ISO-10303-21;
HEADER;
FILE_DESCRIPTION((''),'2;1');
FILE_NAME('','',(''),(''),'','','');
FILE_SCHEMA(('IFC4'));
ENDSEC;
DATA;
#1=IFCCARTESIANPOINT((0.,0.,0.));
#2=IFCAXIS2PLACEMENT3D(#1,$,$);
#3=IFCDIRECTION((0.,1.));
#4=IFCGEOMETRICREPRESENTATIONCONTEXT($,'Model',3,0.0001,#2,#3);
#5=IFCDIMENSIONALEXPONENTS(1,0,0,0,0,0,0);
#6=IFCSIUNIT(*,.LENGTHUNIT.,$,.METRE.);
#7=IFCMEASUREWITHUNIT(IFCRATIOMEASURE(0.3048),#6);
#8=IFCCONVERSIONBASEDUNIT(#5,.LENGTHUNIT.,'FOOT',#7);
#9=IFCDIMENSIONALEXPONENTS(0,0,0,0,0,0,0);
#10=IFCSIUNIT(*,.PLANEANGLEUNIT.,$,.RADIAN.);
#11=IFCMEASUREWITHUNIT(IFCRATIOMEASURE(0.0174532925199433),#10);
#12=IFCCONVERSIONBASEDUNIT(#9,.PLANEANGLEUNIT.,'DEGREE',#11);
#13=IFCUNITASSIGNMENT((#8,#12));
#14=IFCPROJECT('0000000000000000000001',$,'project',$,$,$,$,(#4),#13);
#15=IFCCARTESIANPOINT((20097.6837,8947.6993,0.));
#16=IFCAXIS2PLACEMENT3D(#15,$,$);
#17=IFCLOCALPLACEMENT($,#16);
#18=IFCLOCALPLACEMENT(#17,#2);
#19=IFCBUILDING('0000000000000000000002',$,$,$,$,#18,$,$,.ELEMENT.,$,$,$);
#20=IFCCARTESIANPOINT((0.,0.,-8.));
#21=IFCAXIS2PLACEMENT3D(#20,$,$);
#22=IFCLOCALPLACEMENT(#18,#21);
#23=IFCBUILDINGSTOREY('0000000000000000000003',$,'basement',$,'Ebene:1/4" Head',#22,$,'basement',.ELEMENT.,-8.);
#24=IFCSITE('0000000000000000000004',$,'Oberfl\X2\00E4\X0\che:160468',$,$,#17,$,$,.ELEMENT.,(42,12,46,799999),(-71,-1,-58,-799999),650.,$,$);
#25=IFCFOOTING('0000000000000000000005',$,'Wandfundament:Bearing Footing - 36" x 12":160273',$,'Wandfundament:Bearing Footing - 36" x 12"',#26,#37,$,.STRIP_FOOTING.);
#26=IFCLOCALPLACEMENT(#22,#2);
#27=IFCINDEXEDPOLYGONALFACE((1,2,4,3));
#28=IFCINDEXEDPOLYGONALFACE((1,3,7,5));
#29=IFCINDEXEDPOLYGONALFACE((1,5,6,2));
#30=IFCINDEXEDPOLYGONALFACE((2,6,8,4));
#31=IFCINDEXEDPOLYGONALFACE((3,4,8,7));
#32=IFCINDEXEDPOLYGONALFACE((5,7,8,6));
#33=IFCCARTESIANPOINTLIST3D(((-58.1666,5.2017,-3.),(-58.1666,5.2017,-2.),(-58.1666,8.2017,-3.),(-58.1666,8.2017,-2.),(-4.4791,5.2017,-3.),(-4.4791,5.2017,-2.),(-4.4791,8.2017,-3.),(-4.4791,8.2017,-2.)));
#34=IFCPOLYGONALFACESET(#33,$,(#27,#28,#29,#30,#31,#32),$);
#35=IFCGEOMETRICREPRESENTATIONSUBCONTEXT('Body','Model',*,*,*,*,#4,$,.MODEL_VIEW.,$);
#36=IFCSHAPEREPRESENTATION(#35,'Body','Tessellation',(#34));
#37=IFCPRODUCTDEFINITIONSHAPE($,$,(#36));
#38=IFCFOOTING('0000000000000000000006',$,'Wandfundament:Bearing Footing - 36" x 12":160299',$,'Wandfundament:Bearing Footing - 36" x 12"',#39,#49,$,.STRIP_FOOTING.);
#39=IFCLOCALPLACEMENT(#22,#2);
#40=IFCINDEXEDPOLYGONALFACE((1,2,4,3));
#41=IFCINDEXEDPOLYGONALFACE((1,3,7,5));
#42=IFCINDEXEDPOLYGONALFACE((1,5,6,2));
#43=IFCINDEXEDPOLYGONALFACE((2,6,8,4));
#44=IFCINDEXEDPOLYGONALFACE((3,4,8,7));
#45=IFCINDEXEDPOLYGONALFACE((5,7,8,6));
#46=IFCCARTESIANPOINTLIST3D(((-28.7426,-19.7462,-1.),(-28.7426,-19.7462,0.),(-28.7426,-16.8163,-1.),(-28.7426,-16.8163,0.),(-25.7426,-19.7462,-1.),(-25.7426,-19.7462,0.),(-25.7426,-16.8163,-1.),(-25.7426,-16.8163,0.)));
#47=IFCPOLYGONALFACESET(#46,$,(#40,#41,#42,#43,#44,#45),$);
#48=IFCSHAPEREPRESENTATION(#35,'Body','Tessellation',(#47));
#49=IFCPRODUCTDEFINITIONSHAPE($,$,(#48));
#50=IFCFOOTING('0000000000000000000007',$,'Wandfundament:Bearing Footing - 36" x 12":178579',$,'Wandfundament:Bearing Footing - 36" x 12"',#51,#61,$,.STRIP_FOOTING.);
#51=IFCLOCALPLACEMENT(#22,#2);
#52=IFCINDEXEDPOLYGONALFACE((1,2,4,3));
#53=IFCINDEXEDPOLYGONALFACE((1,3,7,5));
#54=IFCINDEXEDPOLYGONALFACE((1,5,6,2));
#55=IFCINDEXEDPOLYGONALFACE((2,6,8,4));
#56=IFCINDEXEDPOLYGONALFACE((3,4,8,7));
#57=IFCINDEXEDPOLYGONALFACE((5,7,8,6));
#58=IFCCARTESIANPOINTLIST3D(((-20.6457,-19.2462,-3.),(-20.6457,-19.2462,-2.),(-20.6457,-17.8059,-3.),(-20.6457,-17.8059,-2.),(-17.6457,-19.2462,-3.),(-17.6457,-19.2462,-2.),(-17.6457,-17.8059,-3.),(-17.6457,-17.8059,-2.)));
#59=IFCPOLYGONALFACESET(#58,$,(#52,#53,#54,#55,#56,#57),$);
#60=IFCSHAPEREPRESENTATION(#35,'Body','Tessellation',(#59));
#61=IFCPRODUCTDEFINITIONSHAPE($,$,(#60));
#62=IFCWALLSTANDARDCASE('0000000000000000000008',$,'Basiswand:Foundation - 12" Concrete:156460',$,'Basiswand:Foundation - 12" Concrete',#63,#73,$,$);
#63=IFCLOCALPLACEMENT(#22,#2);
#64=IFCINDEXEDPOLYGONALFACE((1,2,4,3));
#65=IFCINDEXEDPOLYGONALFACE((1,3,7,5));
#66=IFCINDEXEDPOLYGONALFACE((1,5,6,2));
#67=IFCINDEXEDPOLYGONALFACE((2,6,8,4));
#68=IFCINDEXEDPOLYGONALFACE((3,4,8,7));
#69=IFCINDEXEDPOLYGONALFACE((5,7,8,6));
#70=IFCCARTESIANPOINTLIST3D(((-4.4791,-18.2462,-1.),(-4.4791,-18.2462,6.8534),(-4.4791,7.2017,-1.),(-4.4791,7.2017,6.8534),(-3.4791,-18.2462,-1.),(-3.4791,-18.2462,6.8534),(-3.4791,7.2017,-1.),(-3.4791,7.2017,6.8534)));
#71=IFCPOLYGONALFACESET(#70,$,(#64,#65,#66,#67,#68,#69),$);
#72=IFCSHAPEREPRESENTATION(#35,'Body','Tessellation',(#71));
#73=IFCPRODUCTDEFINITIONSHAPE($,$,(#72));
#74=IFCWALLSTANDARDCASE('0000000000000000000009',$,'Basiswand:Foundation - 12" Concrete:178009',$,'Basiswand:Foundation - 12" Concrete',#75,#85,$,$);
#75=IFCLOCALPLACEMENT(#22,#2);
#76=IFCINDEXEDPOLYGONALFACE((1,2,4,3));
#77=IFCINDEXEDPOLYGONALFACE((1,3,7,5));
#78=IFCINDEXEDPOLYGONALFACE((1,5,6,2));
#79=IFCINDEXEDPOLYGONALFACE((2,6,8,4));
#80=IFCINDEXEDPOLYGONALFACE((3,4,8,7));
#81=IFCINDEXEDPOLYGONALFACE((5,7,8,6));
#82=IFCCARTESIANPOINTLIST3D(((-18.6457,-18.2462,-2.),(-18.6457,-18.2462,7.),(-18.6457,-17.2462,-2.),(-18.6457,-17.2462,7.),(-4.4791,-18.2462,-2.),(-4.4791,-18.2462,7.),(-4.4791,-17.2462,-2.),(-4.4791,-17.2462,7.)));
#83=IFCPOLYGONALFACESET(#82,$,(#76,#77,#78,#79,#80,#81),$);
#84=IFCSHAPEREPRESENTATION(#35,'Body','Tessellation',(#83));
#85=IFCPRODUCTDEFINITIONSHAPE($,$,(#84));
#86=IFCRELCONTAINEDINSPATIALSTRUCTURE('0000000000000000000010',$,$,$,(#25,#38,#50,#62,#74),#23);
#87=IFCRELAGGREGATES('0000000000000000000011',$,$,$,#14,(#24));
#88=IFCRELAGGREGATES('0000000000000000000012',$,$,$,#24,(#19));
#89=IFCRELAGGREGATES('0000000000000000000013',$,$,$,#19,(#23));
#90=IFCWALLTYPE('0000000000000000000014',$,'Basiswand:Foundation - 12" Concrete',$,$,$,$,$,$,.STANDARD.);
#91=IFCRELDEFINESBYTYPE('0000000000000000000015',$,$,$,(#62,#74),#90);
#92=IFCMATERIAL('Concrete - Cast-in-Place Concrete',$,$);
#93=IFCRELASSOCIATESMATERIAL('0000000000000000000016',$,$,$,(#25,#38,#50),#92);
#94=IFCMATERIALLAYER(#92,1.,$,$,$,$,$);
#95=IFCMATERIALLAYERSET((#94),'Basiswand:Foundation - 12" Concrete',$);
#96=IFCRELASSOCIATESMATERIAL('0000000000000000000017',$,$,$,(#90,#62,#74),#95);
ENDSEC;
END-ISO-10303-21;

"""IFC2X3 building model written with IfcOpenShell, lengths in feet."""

from ifc_helpers import new_model, entity, si_unit, converted_unit, direction, frame, frame_2d, origin, place, context, subcontext, project, spatial, rectangle, extrude, material, layer, layer_set, layer_usage, type_object, element, save


model = new_model("IFC2X3")

# Units and contexts
model_context = context("Model", 3, precision=0.0001, world=origin(), true_north=direction((0.0, 1.0)))
body_context = subcontext(model_context, "Body", "Model", "MODEL_VIEW")
ifc_project = project(units=[converted_unit("LENGTHUNIT", "FOOT", entity("IfcRatioMeasure", 0.3048), si_unit("LENGTHUNIT", "METRE"), dimensions=[1, 0, 0, 0, 0, 0, 0]), converted_unit("PLANEANGLEUNIT", "DEGREE", entity("IfcRatioMeasure", 0.0174532925199433), si_unit("PLANEANGLEUNIT", "RADIAN"), dimensions=[0, 0, 0, 0, 0, 0, 0])], contexts=[model_context])

# Site, building, storey
site_placement = place(None, frame((20097.6837, 8947.6993, 0.0)))
site = spatial("IfcSite", under=ifc_project, at=site_placement, Name="Oberfläche:160468", CompositionType="ELEMENT", RefLatitude=(42, 12, 46, 799999), RefLongitude=(-71, -1, -58, -799999), RefElevation=650.0)
building_placement = place(site_placement, origin())
building = spatial("IfcBuilding", under=site, at=building_placement, CompositionType="ELEMENT")
storey_placement = place(building_placement, frame((0.0, 0.0, -8.0)))
storey = spatial("IfcBuildingStorey", under=building, at=storey_placement, Name="basement", ObjectType="Ebene:1/4\" Head", LongName="basement", CompositionType="ELEMENT", Elevation=-8.0)

# Footings
ifc_material_1 = material(Name="Concrete - Cast-in-Place Concrete")
footing_1_placement = place(storey_placement, origin())
element("IfcFooting", 1, at=footing_1_placement, inside=storey, material=ifc_material_1, Name="Wandfundament:Bearing Footing - 36\" x 12\":160273", ObjectType="Wandfundament:Bearing Footing - 36\" x 12\"", PredefinedType="STRIP_FOOTING", context=body_context, shape_type="SweptSolid", body=[
    extrude(rectangle(XDim=53.6875, YDim=3.0, at=frame_2d((0.0, 0.0), x_axis=(1.0, 0.0))), frame((-31.3228, 6.7017, -3.0), z_axis=(0.0, 0.0, 1.0), x_axis=(-1.0, 0.0, 0.0)), (0.0, 0.0, 1.0), 1.0),
])
footing_2_placement = place(storey_placement, origin())
element("IfcFooting", 2, at=footing_2_placement, inside=storey, material=ifc_material_1, Name="Wandfundament:Bearing Footing - 36\" x 12\":160299", ObjectType="Wandfundament:Bearing Footing - 36\" x 12\"", PredefinedType="STRIP_FOOTING", context=body_context, shape_type="SweptSolid", body=[
    extrude(rectangle(XDim=2.9299, YDim=3.0, at=frame_2d((0.0, 0.0), x_axis=(1.0, 0.0))), frame((-27.2426, -18.2813, -1.0), z_axis=(0.0, 0.0, 1.0), x_axis=(0.0, -1.0, 0.0)), (0.0, 0.0, 1.0), 1.0),
])
footing_3_placement = place(storey_placement, origin())
element("IfcFooting", 3, at=footing_3_placement, inside=storey, material=ifc_material_1, Name="Wandfundament:Bearing Footing - 36\" x 12\":178579", ObjectType="Wandfundament:Bearing Footing - 36\" x 12\"", PredefinedType="STRIP_FOOTING", context=body_context, shape_type="SweptSolid", body=[
    extrude(rectangle(XDim=1.4403, YDim=3.0, at=frame_2d((0.0, 0.0), x_axis=(1.0, 0.0))), frame((-19.1457, -18.5261, -3.0), z_axis=(0.0, 0.0, 1.0), x_axis=(0.0, 1.0, 0.0)), (0.0, 0.0, 1.0), 1.0),
])

# Walls
ifc_layer_1 = layer(ifc_material_1, 1.0)
ifc_layer_set_1 = layer_set([ifc_layer_1], Name="Basiswand:Foundation - 12\" Concrete")
ifc_layer_usage_1 = layer_usage(ifc_layer_set_1, "AXIS2", "POSITIVE", -0.5)
wall_type = type_object("IfcWallType", Name="Basiswand:Foundation - 12\" Concrete", PredefinedType="STANDARD", material=ifc_layer_set_1)
wall_1_placement = place(storey_placement, frame((-3.9791, -18.2462, -1.0), z_axis=(0.0, 0.0, 1.0), x_axis=(0.0, 1.0, 0.0)))
element("IfcWallStandardCase", 4, at=wall_1_placement, inside=storey, type_object=wall_type, material=ifc_layer_usage_1, Name="Basiswand:Foundation - 12\" Concrete:156460", ObjectType="Basiswand:Foundation - 12\" Concrete", context=body_context, shape_type="SweptSolid", body=[
    extrude(rectangle(XDim=25.4479, YDim=1.0, at=frame_2d((12.724, 0.0), x_axis=(-1.0, 0.0))), origin(), (0.0, 0.0, 1.0), 7.8534),
])
ifc_layer_usage_2 = layer_usage(ifc_layer_set_1, "AXIS2", "POSITIVE", -0.5)
wall_2_placement = place(storey_placement, frame((-4.4791, -17.7462, -2.0), z_axis=(0.0, 0.0, 1.0), x_axis=(-1.0, 0.0, 0.0)))
element("IfcWallStandardCase", 5, at=wall_2_placement, inside=storey, type_object=wall_type, material=ifc_layer_usage_2, Name="Basiswand:Foundation - 12\" Concrete:178009", ObjectType="Basiswand:Foundation - 12\" Concrete", context=body_context, shape_type="SweptSolid", body=[
    extrude(rectangle(XDim=14.1667, YDim=1.0, at=frame_2d((7.0833, 0.0), x_axis=(-1.0, 0.0))), origin(), (0.0, 0.0, 1.0), 9.0),
])

save(model, "model.ifc")
